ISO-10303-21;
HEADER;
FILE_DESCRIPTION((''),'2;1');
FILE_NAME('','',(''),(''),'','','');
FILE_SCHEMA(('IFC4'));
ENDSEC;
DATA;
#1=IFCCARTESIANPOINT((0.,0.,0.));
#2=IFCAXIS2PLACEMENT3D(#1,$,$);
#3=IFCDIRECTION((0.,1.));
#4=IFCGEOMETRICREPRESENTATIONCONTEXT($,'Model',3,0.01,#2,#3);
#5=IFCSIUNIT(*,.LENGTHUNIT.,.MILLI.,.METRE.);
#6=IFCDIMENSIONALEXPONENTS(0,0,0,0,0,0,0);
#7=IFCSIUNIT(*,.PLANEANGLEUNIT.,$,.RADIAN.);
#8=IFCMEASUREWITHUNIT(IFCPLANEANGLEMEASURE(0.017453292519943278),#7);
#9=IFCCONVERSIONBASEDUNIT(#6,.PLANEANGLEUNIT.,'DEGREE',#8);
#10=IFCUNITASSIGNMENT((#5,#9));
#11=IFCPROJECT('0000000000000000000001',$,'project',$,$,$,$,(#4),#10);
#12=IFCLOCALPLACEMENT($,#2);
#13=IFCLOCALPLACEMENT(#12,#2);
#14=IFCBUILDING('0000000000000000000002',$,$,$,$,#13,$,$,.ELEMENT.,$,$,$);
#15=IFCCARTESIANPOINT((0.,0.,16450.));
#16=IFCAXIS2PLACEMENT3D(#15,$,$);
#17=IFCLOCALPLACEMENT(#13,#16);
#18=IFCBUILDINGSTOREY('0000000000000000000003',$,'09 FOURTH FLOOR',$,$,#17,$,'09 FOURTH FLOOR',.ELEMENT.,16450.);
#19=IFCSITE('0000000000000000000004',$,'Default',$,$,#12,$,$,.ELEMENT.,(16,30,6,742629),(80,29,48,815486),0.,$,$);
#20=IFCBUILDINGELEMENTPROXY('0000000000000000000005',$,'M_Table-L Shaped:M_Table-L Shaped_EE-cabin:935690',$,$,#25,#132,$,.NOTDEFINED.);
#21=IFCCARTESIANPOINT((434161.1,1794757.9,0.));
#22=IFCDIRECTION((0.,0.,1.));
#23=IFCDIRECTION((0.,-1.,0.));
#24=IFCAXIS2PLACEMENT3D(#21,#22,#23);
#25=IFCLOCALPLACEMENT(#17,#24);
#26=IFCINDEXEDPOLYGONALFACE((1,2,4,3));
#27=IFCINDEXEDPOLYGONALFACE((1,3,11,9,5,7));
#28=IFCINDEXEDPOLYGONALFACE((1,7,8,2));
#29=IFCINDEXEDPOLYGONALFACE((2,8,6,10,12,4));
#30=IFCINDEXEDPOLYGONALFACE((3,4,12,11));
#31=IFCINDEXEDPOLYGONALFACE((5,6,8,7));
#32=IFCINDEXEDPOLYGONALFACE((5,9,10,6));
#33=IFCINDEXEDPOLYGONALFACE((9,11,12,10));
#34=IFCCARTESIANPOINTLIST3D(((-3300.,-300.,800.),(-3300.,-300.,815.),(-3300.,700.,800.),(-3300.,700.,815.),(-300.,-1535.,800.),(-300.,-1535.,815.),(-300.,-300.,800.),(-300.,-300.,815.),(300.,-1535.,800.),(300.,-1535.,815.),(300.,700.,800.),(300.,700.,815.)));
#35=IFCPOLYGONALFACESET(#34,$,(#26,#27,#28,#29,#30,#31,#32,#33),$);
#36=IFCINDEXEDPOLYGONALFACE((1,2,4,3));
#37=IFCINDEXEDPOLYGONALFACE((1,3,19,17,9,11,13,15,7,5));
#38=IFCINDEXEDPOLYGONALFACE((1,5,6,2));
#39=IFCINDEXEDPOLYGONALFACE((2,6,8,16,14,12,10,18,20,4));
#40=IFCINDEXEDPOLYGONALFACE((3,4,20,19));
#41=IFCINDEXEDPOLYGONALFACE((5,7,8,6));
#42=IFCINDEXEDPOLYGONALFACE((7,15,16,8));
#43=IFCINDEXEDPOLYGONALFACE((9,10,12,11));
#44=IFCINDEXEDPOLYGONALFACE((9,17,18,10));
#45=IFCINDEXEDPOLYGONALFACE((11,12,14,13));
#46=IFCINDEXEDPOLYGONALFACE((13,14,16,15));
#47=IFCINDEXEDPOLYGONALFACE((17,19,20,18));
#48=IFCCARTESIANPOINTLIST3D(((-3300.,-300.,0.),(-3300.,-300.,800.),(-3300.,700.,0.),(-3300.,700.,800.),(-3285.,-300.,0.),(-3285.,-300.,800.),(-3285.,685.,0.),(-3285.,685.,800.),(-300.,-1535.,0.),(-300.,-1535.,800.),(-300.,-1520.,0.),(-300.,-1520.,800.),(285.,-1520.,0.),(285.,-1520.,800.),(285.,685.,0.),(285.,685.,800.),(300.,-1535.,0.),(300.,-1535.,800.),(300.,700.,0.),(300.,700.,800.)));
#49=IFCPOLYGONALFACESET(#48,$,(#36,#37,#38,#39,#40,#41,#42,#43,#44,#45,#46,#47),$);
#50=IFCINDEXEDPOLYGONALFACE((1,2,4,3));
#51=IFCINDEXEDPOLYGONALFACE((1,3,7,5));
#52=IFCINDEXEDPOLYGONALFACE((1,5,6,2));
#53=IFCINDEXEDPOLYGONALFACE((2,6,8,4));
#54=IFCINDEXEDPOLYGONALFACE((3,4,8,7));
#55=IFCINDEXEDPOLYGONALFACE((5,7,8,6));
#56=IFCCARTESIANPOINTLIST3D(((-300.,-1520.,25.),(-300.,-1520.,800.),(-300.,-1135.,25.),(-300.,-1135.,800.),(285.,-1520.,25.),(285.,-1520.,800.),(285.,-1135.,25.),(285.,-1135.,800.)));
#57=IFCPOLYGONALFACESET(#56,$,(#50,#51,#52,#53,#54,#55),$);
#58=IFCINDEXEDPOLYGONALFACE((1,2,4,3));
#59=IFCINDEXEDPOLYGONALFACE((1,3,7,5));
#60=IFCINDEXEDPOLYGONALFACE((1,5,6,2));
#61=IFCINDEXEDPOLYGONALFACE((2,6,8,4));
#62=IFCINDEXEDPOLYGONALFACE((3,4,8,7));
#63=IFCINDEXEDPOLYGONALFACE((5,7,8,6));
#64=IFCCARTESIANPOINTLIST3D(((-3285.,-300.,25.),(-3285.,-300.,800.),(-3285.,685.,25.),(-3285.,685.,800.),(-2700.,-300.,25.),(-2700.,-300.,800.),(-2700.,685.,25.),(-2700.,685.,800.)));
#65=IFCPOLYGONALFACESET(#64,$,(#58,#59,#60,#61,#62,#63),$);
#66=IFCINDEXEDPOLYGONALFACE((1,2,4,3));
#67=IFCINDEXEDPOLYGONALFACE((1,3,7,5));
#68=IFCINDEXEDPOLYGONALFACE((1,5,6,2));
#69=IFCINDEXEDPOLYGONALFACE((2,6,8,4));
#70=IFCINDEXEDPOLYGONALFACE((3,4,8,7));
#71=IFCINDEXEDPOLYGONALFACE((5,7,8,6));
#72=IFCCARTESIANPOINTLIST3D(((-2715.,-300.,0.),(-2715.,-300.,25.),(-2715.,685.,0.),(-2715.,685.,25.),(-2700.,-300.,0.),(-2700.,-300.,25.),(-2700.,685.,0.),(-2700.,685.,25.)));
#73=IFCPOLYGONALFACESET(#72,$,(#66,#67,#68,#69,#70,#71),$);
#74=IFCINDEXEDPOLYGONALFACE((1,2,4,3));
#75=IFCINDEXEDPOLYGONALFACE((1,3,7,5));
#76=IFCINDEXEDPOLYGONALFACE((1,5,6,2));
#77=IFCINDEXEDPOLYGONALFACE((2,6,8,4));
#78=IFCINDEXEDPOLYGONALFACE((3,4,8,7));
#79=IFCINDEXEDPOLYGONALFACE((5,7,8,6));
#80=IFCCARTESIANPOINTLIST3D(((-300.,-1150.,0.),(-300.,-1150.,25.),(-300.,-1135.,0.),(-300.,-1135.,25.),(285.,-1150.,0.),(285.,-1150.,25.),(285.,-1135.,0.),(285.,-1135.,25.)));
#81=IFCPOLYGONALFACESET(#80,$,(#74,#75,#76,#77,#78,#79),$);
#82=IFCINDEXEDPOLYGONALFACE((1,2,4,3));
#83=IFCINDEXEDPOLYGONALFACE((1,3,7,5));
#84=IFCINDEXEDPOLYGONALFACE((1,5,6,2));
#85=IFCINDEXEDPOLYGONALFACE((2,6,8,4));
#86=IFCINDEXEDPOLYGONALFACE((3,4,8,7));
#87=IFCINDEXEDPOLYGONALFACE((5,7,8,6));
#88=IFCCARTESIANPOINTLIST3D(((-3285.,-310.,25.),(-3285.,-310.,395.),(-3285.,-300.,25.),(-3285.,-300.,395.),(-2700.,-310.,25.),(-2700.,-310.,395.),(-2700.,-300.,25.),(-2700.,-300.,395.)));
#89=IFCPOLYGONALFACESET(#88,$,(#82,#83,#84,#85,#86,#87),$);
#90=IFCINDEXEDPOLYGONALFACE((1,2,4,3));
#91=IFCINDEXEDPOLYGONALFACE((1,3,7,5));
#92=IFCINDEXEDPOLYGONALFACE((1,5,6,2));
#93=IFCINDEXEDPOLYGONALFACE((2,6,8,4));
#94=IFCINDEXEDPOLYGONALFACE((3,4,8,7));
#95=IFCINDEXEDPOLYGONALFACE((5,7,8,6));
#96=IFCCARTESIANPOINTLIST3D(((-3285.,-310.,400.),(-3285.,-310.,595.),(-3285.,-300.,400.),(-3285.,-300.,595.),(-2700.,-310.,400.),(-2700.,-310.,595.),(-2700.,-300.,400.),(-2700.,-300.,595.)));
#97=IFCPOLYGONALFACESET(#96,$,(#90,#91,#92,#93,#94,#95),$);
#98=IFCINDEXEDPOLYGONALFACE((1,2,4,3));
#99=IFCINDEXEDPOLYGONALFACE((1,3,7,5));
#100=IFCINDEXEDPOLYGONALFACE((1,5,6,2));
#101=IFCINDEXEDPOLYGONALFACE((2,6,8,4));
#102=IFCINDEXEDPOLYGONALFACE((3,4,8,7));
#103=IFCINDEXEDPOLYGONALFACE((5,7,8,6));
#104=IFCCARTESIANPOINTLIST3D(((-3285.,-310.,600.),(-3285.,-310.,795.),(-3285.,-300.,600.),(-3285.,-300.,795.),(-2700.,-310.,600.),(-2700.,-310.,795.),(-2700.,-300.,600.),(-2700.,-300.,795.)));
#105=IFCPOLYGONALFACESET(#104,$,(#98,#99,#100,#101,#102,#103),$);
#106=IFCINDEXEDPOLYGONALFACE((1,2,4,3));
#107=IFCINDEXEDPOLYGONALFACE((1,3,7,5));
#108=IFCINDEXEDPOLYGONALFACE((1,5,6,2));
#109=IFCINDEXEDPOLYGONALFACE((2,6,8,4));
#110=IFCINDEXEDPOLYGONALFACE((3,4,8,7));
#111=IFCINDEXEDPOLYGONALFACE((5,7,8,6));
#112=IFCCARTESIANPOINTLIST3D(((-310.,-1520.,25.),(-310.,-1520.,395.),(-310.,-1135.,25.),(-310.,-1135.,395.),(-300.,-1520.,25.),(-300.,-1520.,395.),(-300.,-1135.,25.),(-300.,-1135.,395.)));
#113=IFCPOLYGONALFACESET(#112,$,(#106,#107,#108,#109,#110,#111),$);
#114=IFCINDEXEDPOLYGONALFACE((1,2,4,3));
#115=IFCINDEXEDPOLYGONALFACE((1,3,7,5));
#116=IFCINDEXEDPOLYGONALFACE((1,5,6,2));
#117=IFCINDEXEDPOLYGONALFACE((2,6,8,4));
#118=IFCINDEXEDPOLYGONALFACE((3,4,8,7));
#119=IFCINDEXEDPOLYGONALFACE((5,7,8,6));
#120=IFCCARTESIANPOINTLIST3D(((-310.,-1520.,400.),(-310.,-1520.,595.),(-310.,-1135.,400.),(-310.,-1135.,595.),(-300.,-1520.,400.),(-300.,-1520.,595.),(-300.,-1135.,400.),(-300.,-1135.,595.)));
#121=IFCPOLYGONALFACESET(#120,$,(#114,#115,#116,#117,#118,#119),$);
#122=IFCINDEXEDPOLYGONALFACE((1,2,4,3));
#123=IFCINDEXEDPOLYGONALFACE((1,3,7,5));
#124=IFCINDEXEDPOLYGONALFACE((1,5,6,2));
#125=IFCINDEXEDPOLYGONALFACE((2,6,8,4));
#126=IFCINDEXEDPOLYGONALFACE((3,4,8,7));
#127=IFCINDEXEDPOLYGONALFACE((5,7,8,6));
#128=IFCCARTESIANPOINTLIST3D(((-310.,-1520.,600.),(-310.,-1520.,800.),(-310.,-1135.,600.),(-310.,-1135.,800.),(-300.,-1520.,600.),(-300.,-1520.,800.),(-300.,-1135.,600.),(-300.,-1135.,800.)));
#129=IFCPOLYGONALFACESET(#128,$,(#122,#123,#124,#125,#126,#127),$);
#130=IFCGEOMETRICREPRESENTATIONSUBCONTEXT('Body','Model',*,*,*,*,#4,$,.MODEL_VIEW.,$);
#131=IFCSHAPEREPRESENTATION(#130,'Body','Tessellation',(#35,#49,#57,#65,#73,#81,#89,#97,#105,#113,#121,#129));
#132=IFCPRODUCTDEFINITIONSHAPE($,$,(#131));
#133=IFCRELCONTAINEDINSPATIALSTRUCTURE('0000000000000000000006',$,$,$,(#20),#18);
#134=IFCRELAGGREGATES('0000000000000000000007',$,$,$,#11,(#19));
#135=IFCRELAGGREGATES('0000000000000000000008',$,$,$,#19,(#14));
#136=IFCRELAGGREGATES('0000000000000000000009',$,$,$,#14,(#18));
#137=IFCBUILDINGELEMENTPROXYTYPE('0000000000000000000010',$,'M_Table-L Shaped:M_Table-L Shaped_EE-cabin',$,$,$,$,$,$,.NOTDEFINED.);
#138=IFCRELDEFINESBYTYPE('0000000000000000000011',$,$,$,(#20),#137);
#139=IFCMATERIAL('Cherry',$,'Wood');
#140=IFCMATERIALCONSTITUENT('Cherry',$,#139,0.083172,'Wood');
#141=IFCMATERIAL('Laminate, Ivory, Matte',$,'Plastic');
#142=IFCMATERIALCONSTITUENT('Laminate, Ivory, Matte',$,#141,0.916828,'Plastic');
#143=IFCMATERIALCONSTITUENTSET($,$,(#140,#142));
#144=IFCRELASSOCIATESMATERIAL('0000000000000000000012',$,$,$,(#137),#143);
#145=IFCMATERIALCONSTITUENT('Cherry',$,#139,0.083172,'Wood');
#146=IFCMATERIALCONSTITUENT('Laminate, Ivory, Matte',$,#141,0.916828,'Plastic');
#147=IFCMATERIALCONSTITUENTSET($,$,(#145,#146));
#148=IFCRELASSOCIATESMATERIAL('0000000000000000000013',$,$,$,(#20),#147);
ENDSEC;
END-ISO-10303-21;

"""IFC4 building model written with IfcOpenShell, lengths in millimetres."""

from ifc_helpers import new_model, entity, si_unit, converted_unit, direction, frame, origin, place, context, subcontext, project, spatial, indexed_curve, outline, extrude, source, transform, mapped, material, constituent, constituent_set, type_object, type_shapes, element, save


model = new_model("IFC4")

# Units and contexts
model_context = context("Model", 3, precision=0.01, world=origin(), true_north=direction((0.0, 1.0)))
body_context = subcontext(model_context, "Body", "Model", "MODEL_VIEW")
ifc_project = project(units=[si_unit("LENGTHUNIT", "METRE", prefix="MILLI"), converted_unit("PLANEANGLEUNIT", "DEGREE", entity("IfcPlaneAngleMeasure", 0.017453292519943278), si_unit("PLANEANGLEUNIT", "RADIAN"), dimensions=[0, 0, 0, 0, 0, 0, 0])], contexts=[model_context])

# Site, building, storey
site_placement = place(None, origin())
site = spatial("IfcSite", under=ifc_project, at=site_placement, Name="Default", CompositionType="ELEMENT", RefLatitude=(16, 30, 6, 742629), RefLongitude=(80, 29, 48, 815486), RefElevation=0.0)
building_placement = place(site_placement, origin())
building = spatial("IfcBuilding", under=site, at=building_placement, CompositionType="ELEMENT")
storey_placement = place(building_placement, frame((0.0, 0.0, 16450.0)))
storey = spatial("IfcBuildingStorey", under=building, at=storey_placement, Name="09 FOURTH FLOOR", LongName="09 FOURTH FLOOR", CompositionType="ELEMENT", Elevation=16450.0)

# Shared definitions
ifc_material_1 = material(Name="Laminate, Ivory, Matte", Category="Plastic")

# Building element proxy
ifc_material_2 = material(Name="Cherry", Category="Wood")
ifc_constituent_1 = constituent(ifc_material_2, Name="Cherry", Category="Wood", fraction=0.083172)
ifc_constituent_2 = constituent(ifc_material_1, Name="Laminate, Ivory, Matte", Category="Plastic", fraction=0.916828)
ifc_constituent_set_1 = constituent_set(constituents=[ifc_constituent_1, ifc_constituent_2])
ifc_constituent_3 = constituent(ifc_material_2, Name="Cherry", Category="Wood", fraction=0.083172)
ifc_constituent_4 = constituent(ifc_material_1, Name="Laminate, Ivory, Matte", Category="Plastic", fraction=0.916828)
ifc_constituent_set_2 = constituent_set(constituents=[ifc_constituent_3, ifc_constituent_4])
building_element_proxy_type = type_object("IfcBuildingElementProxyType", Name="M_Table-L Shaped:M_Table-L Shaped_EE-cabin", PredefinedType="NOTDEFINED", material=ifc_constituent_set_2)
shared_shape_1 = source(origin(), body_context, "Body", "SweptSolid", [
    extrude(outline(indexed_curve([(800.0, -1156.7), (1400.0, -1156.7), (1400.0, 1078.3), (-2200.0, 1078.3), (-2200.0, 78.3), (800.0, 78.3), (800.0, -1156.7)], self_intersect=False)), frame((-1100.0, -378.3, 800.0)), (0.0, 0.0, 1.0), 15.0),
    extrude(outline(indexed_curve([(960.0, -1141.0), (1560.0, -1141.0), (1560.0, 1094.0), (-2040.0, 1094.0), (-2040.0, 94.0), (-2025.0, 94.0), (-2025.0, 1079.0), (1545.0, 1079.0), (1545.0, -1126.0), (960.0, -1126.0), (960.0, -1141.0)], self_intersect=False)), frame((-1260.0, -394.0, 0.0)), (0.0, 0.0, 1.0), 800.0),
    extrude(outline(indexed_curve([(-192.5, -292.5), (192.5, -292.5), (192.5, 292.5), (-192.5, 292.5), (-192.5, -292.5)], self_intersect=False)), frame((-7.5, -1327.5, 25.0), z_axis=(0.0, 0.0, 1.0), x_axis=(0.0, 1.0, 0.0)), (0.0, 0.0, 1.0), 775.0),
    extrude(outline(indexed_curve([(-292.5, -492.5), (292.5, -492.5), (292.5, 492.5), (-292.5, 492.5), (-292.5, -492.5)], self_intersect=False)), frame((-2992.5, 192.5, 25.0)), (0.0, 0.0, 1.0), 775.0),
    extrude(outline(indexed_curve([(-492.5, -7.5), (492.5, -7.5), (492.5, 7.5), (-492.5, 7.5), (-492.5, -7.5)], self_intersect=False)), frame((-2707.5, 192.5, 0.0), z_axis=(0.0, 0.0, 1.0), x_axis=(0.0, 1.0, 0.0)), (0.0, 0.0, 1.0), 25.0),
    extrude(outline(indexed_curve([(-292.5, -7.5), (292.5, -7.5), (292.5, 7.5), (-292.5, 7.5), (-292.5, -7.5)], self_intersect=False)), frame((-7.5, -1142.5, 0.0), z_axis=(0.0, 0.0, 1.0), x_axis=(-1.0, 0.0, 0.0)), (0.0, 0.0, 1.0), 25.0),
    extrude(outline(indexed_curve([(-292.5, -5.0), (292.5, -5.0), (292.5, 5.0), (-292.5, 5.0), (-292.5, -5.0)], self_intersect=False)), frame((-2992.5, -305.0, 25.0), z_axis=(0.0, 0.0, 1.0), x_axis=(-1.0, 0.0, 0.0)), (0.0, 0.0, 1.0), 370.0),
    extrude(outline(indexed_curve([(-292.5, -5.0), (292.5, -5.0), (292.5, 5.0), (-292.5, 5.0), (-292.5, -5.0)], self_intersect=False)), frame((-2992.5, -305.0, 400.0), z_axis=(0.0, 0.0, 1.0), x_axis=(-1.0, 0.0, 0.0)), (0.0, 0.0, 1.0), 195.0),
    extrude(outline(indexed_curve([(-292.5, -5.0), (292.5, -5.0), (292.5, 5.0), (-292.5, 5.0), (-292.5, -5.0)], self_intersect=False)), frame((-2992.5, -305.0, 600.0), z_axis=(0.0, 0.0, 1.0), x_axis=(-1.0, 0.0, 0.0)), (0.0, 0.0, 1.0), 195.0),
    extrude(outline(indexed_curve([(-5.0, -192.5), (5.0, -192.5), (5.0, 192.5), (-5.0, 192.5), (-5.0, -192.5)], self_intersect=False)), frame((-305.0, -1327.5, 25.0)), (0.0, 0.0, 1.0), 370.0),
    extrude(outline(indexed_curve([(-5.0, -192.5), (5.0, -192.5), (5.0, 192.5), (-5.0, 192.5), (-5.0, -192.5)], self_intersect=False)), frame((-305.0, -1327.5, 400.0)), (0.0, 0.0, 1.0), 195.0),
    extrude(outline(indexed_curve([(-5.0, -192.5), (5.0, -192.5), (5.0, 192.5), (-5.0, 192.5), (-5.0, -192.5)], self_intersect=False)), frame((-305.0, -1327.5, 600.0)), (0.0, 0.0, 1.0), 200.0),
])
type_shapes(building_element_proxy_type, [shared_shape_1])
proxy_placement = place(storey_placement, frame((434161.1, 1794757.9, 0.0), z_axis=(0.0, 0.0, 1.0), x_axis=(0.0, -1.0, 0.0)))
element("IfcBuildingElementProxy", 1, at=proxy_placement, inside=storey, type_object=building_element_proxy_type, material=ifc_constituent_set_1, Name="M_Table-L Shaped:M_Table-L Shaped_EE-cabin:935690", PredefinedType="NOTDEFINED", context=body_context, shape_type="MappedRepresentation", body=[
    mapped(shared_shape_1, transform((0.0, 0.0, 0.0), scale=1.0)),
])

save(model, "model.ifc")
